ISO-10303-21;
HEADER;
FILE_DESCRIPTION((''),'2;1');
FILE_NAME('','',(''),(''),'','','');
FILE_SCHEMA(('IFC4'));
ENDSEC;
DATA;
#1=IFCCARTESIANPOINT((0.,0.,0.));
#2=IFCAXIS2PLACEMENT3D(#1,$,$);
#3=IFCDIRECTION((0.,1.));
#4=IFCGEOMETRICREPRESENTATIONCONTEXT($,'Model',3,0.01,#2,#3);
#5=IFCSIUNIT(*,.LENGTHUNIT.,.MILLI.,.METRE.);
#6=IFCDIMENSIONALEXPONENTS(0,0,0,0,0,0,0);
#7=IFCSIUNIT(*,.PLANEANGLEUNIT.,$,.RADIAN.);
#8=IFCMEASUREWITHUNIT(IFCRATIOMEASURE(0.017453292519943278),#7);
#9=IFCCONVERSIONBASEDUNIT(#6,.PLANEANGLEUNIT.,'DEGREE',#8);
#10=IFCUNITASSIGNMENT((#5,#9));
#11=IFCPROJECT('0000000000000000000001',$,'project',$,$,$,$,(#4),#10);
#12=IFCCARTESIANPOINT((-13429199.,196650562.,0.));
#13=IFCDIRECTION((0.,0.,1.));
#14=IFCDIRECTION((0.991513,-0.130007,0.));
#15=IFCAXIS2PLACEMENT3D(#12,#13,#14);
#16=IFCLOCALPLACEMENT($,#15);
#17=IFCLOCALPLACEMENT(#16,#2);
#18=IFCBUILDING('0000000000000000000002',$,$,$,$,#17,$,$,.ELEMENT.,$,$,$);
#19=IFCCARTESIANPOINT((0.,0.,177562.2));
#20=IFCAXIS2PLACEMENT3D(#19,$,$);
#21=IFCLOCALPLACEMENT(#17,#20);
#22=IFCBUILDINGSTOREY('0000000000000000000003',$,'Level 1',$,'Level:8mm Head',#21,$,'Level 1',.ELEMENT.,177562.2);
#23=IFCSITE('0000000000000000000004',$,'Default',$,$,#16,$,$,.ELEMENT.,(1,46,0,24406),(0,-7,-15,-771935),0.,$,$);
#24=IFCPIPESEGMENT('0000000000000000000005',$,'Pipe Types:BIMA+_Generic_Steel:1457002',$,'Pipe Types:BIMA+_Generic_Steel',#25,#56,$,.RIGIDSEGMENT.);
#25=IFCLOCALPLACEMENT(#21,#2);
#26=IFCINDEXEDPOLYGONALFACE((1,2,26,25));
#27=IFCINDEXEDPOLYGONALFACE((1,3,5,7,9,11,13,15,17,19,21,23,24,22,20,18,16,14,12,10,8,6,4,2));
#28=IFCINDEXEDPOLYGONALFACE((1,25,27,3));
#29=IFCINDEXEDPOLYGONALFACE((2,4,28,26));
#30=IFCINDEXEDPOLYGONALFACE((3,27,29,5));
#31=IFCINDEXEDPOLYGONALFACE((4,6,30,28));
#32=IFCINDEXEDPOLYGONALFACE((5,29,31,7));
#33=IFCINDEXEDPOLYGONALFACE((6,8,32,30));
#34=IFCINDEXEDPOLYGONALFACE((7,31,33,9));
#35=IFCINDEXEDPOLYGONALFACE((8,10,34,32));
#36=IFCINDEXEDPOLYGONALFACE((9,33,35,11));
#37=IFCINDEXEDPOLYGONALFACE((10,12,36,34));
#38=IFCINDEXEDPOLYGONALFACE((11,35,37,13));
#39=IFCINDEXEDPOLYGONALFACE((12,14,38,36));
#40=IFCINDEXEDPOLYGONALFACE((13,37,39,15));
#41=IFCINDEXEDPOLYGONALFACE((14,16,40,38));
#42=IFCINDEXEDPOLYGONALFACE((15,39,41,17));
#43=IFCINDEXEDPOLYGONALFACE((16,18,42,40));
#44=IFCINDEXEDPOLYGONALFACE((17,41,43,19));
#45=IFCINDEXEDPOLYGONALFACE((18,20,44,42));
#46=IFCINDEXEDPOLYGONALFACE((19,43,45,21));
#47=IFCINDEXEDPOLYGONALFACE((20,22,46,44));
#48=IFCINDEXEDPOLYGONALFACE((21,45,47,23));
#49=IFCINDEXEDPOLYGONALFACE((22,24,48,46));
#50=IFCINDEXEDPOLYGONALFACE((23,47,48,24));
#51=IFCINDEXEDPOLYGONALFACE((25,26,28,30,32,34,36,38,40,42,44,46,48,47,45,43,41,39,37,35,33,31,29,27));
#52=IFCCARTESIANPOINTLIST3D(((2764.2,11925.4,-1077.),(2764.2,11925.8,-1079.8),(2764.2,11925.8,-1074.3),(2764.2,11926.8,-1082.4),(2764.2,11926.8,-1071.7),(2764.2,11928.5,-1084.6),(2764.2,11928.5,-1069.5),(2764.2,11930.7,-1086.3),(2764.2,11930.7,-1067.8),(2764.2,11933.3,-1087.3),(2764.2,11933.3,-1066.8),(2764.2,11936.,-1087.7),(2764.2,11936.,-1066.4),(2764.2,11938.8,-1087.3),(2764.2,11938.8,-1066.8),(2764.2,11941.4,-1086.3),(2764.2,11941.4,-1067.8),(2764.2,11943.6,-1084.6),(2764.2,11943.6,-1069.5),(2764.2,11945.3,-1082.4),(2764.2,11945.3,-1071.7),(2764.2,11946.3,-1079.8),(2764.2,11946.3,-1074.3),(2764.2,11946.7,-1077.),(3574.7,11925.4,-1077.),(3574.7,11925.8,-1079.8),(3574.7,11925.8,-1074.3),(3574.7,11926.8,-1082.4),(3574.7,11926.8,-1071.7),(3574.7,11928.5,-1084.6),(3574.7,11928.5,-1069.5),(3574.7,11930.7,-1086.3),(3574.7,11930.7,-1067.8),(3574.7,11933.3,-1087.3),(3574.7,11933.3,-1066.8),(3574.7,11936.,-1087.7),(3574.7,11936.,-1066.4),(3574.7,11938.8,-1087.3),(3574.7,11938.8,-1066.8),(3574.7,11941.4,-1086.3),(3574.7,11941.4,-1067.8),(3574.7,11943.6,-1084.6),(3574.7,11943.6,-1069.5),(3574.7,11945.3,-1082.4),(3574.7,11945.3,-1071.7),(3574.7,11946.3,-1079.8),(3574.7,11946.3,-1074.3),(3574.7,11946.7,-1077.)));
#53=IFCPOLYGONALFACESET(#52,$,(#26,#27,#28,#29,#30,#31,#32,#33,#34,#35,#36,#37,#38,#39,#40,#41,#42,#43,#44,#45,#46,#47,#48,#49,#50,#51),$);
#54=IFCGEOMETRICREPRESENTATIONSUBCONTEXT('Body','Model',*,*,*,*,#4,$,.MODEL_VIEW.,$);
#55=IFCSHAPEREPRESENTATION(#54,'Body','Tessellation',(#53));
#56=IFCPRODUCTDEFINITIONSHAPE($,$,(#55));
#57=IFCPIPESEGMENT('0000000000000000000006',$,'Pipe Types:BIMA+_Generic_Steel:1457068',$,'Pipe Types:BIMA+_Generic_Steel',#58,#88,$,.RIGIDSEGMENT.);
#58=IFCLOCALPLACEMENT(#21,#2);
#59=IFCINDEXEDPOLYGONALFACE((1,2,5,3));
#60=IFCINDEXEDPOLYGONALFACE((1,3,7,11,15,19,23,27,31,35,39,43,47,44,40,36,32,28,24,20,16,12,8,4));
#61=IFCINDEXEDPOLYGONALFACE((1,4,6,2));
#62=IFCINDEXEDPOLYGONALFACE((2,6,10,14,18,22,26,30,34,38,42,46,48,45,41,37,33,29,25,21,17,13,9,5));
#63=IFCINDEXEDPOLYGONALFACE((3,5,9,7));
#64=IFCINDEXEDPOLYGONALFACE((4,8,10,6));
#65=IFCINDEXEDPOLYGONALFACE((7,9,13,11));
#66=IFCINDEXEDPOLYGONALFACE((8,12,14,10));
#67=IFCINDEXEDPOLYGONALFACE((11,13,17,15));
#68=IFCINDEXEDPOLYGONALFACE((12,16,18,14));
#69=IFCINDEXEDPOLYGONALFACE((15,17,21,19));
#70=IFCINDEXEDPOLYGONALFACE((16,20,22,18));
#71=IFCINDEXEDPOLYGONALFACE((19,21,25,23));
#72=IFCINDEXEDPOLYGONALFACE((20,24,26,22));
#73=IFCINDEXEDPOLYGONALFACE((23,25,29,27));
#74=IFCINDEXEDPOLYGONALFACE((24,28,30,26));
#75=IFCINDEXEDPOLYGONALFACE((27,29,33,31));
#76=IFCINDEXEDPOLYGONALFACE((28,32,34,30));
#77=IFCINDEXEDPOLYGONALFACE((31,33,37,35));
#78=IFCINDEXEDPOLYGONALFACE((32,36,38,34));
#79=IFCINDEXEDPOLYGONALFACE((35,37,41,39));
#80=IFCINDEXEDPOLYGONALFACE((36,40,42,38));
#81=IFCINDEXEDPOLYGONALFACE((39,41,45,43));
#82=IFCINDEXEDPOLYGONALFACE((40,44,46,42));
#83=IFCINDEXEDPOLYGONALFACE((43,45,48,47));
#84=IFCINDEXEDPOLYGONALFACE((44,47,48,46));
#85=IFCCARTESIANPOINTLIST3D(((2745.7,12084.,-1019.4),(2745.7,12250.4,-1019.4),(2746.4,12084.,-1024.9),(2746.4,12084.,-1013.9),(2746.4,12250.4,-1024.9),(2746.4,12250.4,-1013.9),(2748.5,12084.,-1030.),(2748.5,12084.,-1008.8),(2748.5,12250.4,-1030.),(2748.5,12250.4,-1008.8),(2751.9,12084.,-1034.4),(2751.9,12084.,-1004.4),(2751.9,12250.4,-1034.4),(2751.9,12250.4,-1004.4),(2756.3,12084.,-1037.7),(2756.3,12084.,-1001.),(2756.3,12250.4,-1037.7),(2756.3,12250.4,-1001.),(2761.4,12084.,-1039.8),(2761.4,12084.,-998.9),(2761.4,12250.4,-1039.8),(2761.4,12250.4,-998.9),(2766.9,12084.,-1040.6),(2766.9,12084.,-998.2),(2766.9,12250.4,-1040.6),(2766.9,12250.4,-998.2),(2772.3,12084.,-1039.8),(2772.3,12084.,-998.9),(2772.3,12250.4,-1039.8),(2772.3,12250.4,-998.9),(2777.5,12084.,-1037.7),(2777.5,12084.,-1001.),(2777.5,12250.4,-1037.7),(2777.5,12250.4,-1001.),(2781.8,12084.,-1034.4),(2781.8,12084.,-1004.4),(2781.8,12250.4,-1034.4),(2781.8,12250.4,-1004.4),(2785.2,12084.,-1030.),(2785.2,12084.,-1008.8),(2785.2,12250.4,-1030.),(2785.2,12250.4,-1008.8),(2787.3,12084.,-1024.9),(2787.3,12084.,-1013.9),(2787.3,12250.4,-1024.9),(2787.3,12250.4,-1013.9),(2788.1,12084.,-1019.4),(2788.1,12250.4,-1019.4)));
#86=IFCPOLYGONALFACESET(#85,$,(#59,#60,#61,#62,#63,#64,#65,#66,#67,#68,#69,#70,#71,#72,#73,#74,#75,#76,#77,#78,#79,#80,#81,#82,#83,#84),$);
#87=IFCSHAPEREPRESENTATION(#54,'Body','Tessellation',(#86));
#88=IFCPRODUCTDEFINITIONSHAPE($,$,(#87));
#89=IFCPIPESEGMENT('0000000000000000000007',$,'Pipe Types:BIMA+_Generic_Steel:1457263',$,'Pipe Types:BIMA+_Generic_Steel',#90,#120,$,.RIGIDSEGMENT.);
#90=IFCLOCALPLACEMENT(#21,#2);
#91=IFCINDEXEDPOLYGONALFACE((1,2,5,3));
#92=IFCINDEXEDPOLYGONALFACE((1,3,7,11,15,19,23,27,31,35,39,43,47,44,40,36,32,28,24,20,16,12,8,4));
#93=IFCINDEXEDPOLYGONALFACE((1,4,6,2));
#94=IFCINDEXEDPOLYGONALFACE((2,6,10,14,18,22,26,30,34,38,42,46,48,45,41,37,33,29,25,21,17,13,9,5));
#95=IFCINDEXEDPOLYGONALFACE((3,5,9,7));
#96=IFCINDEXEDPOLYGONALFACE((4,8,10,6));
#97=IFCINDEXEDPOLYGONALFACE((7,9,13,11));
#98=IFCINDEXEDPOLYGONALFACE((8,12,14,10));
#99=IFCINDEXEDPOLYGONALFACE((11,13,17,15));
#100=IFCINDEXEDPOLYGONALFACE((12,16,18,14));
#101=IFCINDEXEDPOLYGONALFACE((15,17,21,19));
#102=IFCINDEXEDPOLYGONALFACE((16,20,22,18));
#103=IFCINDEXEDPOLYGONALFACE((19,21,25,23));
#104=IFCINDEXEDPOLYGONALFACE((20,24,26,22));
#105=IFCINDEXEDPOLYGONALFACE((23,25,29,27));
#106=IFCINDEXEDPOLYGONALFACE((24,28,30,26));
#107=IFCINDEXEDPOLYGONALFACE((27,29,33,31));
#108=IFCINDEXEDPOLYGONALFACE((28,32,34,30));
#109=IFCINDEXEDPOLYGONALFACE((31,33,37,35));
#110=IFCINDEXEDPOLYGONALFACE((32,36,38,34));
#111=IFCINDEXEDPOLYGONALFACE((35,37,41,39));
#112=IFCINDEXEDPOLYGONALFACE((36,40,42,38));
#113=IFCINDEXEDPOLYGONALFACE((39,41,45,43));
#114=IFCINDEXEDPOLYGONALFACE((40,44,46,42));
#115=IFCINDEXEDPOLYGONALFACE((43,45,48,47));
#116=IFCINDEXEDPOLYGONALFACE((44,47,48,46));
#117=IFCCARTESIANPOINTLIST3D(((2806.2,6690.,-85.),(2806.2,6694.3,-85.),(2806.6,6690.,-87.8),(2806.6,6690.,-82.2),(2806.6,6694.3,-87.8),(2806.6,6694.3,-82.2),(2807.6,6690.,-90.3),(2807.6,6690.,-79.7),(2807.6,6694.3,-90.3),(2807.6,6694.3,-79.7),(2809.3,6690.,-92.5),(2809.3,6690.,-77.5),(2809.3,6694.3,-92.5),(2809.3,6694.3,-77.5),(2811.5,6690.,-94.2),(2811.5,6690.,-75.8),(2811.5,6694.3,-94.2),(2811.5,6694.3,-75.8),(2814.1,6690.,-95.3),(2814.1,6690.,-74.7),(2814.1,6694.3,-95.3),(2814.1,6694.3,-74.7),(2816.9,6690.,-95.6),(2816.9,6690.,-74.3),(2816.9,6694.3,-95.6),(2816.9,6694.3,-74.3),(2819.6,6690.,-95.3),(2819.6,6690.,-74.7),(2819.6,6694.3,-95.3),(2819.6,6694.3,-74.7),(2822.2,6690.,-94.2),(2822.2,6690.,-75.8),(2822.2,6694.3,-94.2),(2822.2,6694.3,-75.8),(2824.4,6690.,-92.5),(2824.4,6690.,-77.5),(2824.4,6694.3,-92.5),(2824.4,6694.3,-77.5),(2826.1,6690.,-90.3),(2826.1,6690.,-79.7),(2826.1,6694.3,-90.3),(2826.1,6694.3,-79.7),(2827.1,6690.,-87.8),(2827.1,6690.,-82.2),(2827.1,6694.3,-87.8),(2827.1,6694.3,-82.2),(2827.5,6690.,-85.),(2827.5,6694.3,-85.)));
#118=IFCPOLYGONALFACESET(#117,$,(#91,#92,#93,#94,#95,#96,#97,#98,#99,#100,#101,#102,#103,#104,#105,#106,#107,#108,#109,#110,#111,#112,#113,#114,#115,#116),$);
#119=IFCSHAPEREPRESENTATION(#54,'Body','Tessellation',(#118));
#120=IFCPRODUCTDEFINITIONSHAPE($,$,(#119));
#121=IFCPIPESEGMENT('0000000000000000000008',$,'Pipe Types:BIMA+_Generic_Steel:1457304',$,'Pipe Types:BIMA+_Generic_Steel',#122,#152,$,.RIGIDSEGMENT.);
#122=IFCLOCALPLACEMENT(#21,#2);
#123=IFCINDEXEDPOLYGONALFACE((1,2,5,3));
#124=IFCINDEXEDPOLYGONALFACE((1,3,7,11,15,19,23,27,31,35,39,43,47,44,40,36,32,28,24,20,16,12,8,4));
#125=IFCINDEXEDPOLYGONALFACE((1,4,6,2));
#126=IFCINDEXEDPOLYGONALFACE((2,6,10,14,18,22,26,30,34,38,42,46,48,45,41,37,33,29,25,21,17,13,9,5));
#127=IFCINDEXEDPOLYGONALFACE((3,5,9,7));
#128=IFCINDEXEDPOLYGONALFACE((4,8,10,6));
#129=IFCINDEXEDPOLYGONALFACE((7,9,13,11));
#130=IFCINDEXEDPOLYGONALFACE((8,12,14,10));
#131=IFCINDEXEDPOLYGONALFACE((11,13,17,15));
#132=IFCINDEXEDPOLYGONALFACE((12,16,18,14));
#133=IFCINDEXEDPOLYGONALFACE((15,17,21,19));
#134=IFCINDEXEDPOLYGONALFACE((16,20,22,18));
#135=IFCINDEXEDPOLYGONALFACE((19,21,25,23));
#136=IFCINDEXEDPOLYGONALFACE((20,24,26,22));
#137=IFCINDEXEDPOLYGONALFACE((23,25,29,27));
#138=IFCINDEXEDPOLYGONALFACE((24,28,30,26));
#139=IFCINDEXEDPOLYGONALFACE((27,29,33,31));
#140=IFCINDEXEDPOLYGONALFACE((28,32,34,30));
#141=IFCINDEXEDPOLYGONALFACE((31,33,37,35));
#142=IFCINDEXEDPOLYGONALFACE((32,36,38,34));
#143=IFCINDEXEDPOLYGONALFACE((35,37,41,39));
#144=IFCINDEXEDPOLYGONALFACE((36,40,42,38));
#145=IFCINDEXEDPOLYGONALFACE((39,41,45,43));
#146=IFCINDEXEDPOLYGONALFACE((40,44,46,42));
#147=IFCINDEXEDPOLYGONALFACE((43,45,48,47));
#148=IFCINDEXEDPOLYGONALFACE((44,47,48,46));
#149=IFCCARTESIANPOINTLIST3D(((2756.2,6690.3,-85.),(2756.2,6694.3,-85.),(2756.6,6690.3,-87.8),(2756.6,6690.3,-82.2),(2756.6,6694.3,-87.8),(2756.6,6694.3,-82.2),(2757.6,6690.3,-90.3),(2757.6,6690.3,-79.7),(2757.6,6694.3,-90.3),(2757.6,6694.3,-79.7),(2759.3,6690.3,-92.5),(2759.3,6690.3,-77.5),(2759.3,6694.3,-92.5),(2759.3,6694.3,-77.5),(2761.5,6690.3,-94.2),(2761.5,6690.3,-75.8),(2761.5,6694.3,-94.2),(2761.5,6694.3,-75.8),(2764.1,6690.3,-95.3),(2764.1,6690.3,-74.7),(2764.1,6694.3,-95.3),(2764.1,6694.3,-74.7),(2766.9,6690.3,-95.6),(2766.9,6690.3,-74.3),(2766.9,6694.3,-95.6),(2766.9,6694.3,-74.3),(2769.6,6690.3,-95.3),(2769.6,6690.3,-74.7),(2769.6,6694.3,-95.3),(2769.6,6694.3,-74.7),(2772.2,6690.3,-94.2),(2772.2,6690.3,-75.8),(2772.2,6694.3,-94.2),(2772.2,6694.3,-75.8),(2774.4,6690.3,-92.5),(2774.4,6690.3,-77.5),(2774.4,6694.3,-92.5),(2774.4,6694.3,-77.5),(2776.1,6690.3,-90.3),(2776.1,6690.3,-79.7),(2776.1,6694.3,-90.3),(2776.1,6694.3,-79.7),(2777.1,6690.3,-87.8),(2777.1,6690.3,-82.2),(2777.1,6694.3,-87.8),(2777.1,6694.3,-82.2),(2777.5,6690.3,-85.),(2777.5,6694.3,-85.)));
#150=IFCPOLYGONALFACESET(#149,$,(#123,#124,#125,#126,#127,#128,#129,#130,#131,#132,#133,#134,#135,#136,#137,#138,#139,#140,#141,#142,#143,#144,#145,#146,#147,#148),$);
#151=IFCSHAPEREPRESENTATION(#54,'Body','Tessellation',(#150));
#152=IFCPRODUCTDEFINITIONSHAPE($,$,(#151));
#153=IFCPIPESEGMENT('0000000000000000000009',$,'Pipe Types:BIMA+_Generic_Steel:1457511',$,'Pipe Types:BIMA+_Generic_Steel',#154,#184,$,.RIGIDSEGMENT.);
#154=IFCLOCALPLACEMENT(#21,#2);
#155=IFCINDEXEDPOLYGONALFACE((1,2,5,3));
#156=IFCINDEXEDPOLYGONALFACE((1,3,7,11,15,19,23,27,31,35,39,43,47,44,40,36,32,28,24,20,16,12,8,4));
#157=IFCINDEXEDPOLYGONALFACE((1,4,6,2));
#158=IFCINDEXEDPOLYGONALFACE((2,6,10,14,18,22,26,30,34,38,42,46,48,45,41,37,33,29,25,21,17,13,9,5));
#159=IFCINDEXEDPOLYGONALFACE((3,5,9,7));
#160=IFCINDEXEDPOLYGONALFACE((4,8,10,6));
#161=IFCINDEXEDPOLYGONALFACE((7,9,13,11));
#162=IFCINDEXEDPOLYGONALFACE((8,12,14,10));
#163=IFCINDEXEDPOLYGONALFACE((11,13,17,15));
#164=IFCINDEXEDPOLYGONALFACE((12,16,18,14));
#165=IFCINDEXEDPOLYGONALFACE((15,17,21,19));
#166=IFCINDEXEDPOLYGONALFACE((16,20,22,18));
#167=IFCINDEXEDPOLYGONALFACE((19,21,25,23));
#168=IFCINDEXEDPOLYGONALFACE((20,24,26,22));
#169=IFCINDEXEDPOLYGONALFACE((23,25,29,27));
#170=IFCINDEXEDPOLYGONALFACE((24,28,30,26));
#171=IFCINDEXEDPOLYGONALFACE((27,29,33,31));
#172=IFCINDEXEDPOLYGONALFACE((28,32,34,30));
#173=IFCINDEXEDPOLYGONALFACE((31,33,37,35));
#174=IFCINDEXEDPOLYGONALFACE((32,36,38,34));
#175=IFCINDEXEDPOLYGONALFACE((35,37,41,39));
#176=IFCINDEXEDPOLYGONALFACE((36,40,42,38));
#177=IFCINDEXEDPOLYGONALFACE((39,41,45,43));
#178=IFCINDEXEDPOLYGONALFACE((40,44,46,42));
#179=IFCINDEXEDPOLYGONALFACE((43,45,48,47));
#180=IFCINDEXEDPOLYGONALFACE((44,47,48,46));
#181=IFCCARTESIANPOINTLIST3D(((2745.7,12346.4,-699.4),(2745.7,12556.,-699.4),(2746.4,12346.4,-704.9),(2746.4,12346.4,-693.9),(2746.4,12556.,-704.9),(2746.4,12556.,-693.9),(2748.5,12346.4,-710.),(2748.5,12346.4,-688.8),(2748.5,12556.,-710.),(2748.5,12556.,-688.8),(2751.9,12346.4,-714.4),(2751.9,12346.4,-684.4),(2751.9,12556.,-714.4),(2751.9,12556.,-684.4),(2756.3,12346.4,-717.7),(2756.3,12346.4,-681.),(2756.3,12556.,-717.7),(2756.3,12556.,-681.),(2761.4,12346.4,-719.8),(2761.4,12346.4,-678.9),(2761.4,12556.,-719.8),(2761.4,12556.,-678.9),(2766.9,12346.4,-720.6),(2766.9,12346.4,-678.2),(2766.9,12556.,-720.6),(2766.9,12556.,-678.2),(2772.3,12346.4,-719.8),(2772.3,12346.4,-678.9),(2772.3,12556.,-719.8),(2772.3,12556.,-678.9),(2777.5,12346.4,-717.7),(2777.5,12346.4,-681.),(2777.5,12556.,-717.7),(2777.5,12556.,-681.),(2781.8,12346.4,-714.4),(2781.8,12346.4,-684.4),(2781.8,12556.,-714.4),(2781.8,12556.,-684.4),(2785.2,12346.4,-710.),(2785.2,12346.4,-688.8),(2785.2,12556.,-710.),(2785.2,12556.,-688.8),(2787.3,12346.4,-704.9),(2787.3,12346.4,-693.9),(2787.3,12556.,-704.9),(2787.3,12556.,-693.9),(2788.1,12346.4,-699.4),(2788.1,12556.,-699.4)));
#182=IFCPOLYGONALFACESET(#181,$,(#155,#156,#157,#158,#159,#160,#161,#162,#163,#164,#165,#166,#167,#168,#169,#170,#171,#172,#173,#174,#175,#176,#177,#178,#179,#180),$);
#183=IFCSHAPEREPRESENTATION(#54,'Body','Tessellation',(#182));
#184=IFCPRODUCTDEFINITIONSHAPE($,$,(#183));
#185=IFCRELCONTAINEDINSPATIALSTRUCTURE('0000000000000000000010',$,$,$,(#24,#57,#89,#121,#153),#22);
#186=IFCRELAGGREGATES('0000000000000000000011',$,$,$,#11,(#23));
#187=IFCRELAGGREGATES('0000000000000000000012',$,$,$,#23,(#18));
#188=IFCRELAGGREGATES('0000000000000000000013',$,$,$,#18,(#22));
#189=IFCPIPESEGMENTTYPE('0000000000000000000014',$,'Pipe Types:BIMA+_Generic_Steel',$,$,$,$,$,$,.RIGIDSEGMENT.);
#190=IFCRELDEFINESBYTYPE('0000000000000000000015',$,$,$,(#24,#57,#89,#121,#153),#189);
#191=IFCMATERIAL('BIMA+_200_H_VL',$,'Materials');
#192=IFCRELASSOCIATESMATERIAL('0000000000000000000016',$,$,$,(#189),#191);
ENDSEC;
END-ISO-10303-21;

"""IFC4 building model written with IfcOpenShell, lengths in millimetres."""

from ifc_helpers import new_model, entity, si_unit, converted_unit, direction, frame, origin, place, context, subcontext, project, spatial, arc, indexed_curve, outline, extrude, material, type_object, element, save


model = new_model("IFC4")

# Units and contexts
model_context = context("Model", 3, precision=0.01, world=origin(), true_north=direction((0.0, 1.0)))
body_context = subcontext(model_context, "Body", "Model", "MODEL_VIEW")
ifc_project = project(units=[si_unit("LENGTHUNIT", "METRE", prefix="MILLI"), converted_unit("PLANEANGLEUNIT", "DEGREE", entity("IfcRatioMeasure", 0.017453292519943278), si_unit("PLANEANGLEUNIT", "RADIAN"), dimensions=[0, 0, 0, 0, 0, 0, 0])], contexts=[model_context])

# Site, building, storey
site_placement = place(None, frame((-13429199.0, 196650562.0, 0.0), z_axis=(0.0, 0.0, 1.0), x_axis=(0.991513, -0.130007, 0.0)))
site = spatial("IfcSite", under=ifc_project, at=site_placement, Name="Default", CompositionType="ELEMENT", RefLatitude=(1, 46, 0, 24406), RefLongitude=(0, -7, -15, -771935), RefElevation=0.0)
building_placement = place(site_placement, origin())
building = spatial("IfcBuilding", under=site, at=building_placement, CompositionType="ELEMENT")
storey_placement = place(building_placement, frame((0.0, 0.0, 177562.2)))
storey = spatial("IfcBuildingStorey", under=building, at=storey_placement, Name="Level 1", ObjectType="Level:8mm Head", LongName="Level 1", CompositionType="ELEMENT", Elevation=177562.2)

# Pipe segments
ifc_material_1 = material(Name="BIMA+_200_H_VL", Category="Materials")
pipe_segment_type_1 = type_object("IfcPipeSegmentType", Name="Pipe Types:BIMA+_Generic_Steel", PredefinedType="RIGIDSEGMENT", material=ifc_material_1)
pipe_segment_1_placement = place(storey_placement, frame((2764.2, 11923.8, -1089.3)))
element("IfcPipeSegment", 1, at=pipe_segment_1_placement, inside=storey, type_object=pipe_segment_type_1, Name="Pipe Types:BIMA+_Generic_Steel:1457002", ObjectType="Pipe Types:BIMA+_Generic_Steel", PredefinedType="RIGIDSEGMENT", context=body_context, shape_type="SweptSolid", body=[
    extrude(outline(indexed_curve([(10.6, 0.0), (7.5, 7.5), (0.0, 10.7), (-7.5, 7.5), (-10.6, 0.0), (-7.5, -7.5), (0.0, -10.7), (7.5, -7.5)], segments=[arc(1, 2, 3), arc(3, 4, 5), arc(5, 6, 7), arc(7, 8, 1)], self_intersect=False)), frame((0.0, 12.2, 12.2), z_axis=(1.0, 0.0, 0.0), x_axis=(0.0, -1.0, 0.0)), (0.0, 0.0, 1.0), 810.5),
])
pipe_segment_2_placement = place(storey_placement, frame((2744.1, 12084.0, -996.6)))
element("IfcPipeSegment", 2, at=pipe_segment_2_placement, inside=storey, type_object=pipe_segment_type_1, Name="Pipe Types:BIMA+_Generic_Steel:1457068", ObjectType="Pipe Types:BIMA+_Generic_Steel", PredefinedType="RIGIDSEGMENT", context=body_context, shape_type="SweptSolid", body=[
    extrude(outline(indexed_curve([(21.2, 0.0), (15.0, 15.0), (0.0, 21.2), (-15.0, 15.0), (-21.2, 0.0), (-15.0, -15.0), (0.0, -21.2), (15.0, -15.0)], segments=[arc(1, 2, 3), arc(3, 4, 5), arc(5, 6, 7), arc(7, 8, 1)], self_intersect=False)), frame((22.8, 0.0, -22.8), z_axis=(0.0, 1.0, 0.0), x_axis=(-1.0, 0.0, 0.0)), (0.0, 0.0, 1.0), 166.3),
])
pipe_segment_3_placement = place(storey_placement, frame((2804.6, 6690.0, -97.2)))
element("IfcPipeSegment", 3, at=pipe_segment_3_placement, inside=storey, type_object=pipe_segment_type_1, Name="Pipe Types:BIMA+_Generic_Steel:1457263", ObjectType="Pipe Types:BIMA+_Generic_Steel", PredefinedType="RIGIDSEGMENT", context=body_context, shape_type="SweptSolid", body=[
    extrude(outline(indexed_curve([(10.6, 0.0), (7.5, 7.5), (0.0, 10.7), (-7.5, 7.5), (-10.6, 0.0), (-7.5, -7.5), (0.0, -10.7), (7.5, -7.5)], segments=[arc(1, 2, 3), arc(3, 4, 5), arc(5, 6, 7), arc(7, 8, 1)], self_intersect=False)), frame((12.2, 0.0, 12.2), z_axis=(0.0, 1.0, 0.0), x_axis=(1.0, 0.0, 0.0)), (0.0, 0.0, 1.0), 4.2),
])
pipe_segment_4_placement = place(storey_placement, frame((2754.6, 6690.3, -97.2)))
element("IfcPipeSegment", 4, at=pipe_segment_4_placement, inside=storey, type_object=pipe_segment_type_1, Name="Pipe Types:BIMA+_Generic_Steel:1457304", ObjectType="Pipe Types:BIMA+_Generic_Steel", PredefinedType="RIGIDSEGMENT", context=body_context, shape_type="SweptSolid", body=[
    extrude(outline(indexed_curve([(10.6, 0.0), (7.5, 7.5), (0.0, 10.7), (-7.5, 7.5), (-10.7, 0.0), (-7.5, -7.5), (0.0, -10.7), (7.5, -7.5)], segments=[arc(1, 2, 3), arc(3, 4, 5), arc(5, 6, 7), arc(7, 8, 1)], self_intersect=False)), frame((12.2, 0.0, 12.2), z_axis=(0.0, 1.0, 0.0), x_axis=(-1.0, 0.0, 0.0)), (0.0, 0.0, 1.0), 4.0),
])
pipe_segment_5_placement = place(storey_placement, frame((2744.1, 12346.4, -722.2)))
element("IfcPipeSegment", 5, at=pipe_segment_5_placement, inside=storey, type_object=pipe_segment_type_1, Name="Pipe Types:BIMA+_Generic_Steel:1457511", ObjectType="Pipe Types:BIMA+_Generic_Steel", PredefinedType="RIGIDSEGMENT", context=body_context, shape_type="SweptSolid", body=[
    extrude(outline(indexed_curve([(21.2, 0.0), (15.0, 15.0), (0.0, 21.2), (-15.0, 15.0), (-21.2, 0.0), (-15.0, -15.0), (0.0, -21.2), (15.0, -15.0)], segments=[arc(1, 2, 3), arc(3, 4, 5), arc(5, 6, 7), arc(7, 8, 1)], self_intersect=False)), frame((22.8, 0.0, 22.8), z_axis=(0.0, 1.0, 0.0), x_axis=(-1.0, 0.0, 0.0)), (0.0, 0.0, 1.0), 209.7),
])

save(model, "model.ifc")
